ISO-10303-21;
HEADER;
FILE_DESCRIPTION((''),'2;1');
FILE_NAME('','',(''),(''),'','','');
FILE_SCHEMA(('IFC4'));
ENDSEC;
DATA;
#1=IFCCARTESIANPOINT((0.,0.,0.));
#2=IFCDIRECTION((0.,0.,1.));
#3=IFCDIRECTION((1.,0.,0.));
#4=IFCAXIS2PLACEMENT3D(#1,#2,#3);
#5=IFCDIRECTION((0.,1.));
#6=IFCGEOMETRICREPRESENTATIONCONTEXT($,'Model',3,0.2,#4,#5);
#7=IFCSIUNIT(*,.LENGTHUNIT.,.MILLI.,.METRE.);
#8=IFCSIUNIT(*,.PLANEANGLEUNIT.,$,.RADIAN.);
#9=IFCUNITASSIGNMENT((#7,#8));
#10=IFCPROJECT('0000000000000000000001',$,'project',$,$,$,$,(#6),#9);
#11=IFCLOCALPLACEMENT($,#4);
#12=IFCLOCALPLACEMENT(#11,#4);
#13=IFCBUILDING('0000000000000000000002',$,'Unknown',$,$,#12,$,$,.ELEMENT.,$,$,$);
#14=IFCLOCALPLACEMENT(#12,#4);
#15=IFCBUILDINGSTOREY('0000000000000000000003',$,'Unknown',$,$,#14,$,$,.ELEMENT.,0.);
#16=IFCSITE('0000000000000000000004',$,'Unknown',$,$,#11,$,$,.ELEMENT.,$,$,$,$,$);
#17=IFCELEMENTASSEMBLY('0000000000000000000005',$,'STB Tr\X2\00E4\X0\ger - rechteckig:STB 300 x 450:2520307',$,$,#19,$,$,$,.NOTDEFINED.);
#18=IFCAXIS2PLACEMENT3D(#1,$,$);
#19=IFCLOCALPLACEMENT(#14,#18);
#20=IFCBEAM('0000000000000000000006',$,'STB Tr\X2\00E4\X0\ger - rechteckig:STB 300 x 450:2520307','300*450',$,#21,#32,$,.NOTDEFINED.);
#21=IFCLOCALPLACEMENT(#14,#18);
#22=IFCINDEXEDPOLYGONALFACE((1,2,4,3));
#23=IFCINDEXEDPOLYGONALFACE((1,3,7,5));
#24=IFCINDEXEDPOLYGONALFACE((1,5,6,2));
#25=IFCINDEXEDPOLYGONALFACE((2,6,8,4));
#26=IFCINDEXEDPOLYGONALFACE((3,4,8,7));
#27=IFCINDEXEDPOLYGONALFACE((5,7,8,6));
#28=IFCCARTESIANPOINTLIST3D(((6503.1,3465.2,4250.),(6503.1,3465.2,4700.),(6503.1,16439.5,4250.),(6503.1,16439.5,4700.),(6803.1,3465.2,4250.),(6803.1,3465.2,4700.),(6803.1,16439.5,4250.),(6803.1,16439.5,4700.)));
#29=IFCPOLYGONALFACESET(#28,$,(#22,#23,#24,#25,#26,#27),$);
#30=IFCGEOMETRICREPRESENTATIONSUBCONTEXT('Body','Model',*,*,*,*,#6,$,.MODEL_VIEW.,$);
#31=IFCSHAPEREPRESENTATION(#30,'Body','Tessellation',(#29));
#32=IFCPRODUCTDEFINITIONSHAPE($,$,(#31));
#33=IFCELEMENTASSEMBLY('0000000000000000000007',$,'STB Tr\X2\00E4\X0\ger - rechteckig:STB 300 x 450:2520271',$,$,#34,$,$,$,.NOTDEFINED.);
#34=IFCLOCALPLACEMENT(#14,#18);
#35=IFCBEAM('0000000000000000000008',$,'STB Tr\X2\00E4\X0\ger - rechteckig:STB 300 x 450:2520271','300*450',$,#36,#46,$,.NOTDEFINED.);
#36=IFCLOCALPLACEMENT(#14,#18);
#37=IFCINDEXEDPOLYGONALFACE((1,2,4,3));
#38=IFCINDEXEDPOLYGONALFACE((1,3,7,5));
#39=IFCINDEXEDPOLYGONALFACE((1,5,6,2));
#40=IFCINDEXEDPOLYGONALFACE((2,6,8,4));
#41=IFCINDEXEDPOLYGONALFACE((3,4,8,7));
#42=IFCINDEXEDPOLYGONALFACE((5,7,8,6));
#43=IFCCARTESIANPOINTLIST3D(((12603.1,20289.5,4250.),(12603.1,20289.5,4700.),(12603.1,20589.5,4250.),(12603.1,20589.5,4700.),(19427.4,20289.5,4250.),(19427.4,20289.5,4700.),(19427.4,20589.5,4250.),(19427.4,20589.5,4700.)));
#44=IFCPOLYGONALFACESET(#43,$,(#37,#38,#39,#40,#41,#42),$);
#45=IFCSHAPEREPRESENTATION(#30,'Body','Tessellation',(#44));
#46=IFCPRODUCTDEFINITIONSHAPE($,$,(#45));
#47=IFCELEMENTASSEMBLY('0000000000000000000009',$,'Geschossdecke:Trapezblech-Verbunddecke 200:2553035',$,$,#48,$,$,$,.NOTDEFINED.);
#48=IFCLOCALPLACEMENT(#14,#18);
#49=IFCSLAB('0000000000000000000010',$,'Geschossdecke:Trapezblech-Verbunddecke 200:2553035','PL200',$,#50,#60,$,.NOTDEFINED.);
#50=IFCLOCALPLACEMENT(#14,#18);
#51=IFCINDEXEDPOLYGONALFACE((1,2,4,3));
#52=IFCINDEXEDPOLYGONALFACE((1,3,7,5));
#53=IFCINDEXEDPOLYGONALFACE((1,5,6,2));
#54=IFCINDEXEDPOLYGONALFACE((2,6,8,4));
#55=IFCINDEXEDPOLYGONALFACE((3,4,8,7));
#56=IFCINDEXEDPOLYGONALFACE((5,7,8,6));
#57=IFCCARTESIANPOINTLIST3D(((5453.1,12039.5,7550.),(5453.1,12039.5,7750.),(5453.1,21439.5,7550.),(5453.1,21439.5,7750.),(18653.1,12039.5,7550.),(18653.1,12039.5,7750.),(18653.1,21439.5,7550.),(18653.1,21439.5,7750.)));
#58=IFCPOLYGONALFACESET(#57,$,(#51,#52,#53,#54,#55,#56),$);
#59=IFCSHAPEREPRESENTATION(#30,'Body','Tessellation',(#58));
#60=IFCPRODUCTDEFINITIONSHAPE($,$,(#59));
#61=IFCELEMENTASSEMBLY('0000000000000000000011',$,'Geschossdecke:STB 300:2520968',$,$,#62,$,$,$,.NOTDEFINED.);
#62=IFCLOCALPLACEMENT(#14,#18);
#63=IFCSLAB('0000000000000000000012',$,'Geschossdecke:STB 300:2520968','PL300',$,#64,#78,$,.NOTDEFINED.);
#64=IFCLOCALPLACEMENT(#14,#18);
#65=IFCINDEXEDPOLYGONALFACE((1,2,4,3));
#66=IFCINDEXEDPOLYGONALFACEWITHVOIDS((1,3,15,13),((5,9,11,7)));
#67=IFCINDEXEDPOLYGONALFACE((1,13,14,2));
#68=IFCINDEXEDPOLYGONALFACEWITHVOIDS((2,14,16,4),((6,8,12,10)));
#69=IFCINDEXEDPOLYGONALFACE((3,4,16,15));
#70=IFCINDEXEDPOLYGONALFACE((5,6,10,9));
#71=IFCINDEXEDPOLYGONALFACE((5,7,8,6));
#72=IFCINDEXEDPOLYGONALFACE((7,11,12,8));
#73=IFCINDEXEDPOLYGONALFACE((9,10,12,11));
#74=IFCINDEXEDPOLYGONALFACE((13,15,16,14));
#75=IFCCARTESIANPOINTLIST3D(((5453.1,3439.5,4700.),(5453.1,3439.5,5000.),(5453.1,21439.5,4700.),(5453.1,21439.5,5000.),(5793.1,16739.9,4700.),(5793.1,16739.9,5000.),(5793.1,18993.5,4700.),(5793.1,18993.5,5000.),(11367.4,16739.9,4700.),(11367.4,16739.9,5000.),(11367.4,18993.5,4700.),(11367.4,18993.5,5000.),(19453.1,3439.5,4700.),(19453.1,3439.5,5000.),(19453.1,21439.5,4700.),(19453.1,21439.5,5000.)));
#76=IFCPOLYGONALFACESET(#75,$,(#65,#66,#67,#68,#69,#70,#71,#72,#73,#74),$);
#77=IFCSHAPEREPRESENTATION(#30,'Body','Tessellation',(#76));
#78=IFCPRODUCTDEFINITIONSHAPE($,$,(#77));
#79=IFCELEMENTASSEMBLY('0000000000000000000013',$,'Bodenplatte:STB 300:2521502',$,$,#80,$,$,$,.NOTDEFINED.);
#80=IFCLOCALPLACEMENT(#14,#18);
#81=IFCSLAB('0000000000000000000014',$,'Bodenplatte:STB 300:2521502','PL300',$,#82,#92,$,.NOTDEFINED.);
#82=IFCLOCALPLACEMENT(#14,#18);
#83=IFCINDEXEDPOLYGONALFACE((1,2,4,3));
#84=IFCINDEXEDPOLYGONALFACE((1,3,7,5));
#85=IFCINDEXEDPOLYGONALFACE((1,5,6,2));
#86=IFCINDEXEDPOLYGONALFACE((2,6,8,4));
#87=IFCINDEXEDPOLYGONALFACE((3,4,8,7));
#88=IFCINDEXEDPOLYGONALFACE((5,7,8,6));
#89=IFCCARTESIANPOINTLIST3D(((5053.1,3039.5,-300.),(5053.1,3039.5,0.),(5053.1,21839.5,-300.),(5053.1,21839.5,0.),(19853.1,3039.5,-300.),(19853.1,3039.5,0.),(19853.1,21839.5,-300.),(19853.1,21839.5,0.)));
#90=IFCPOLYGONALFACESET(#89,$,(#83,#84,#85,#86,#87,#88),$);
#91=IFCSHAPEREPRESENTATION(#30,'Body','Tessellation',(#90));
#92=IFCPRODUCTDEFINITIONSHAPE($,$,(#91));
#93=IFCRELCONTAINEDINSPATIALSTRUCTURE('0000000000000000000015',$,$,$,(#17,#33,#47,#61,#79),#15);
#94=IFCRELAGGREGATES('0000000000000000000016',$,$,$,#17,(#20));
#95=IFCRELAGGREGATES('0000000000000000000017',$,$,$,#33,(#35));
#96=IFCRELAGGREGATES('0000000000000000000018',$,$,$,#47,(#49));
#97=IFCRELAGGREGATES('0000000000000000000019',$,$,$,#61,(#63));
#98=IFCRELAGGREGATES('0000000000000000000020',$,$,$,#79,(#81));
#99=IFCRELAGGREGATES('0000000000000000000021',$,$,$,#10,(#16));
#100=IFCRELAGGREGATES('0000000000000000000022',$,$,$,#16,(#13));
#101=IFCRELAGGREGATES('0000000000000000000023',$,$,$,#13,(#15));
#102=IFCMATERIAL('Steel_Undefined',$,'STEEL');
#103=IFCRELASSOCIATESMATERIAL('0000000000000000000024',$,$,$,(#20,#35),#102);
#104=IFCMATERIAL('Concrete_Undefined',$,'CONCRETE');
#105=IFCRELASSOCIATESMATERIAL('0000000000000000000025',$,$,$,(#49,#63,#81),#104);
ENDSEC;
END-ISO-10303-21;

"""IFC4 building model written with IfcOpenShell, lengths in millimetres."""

from ifc_helpers import new_model, si_unit, direction, frame, origin_with_axes, place, context, subcontext, project, spatial, line, indexed_curve, outline, extrude, material, element, aggregate, save


model = new_model("IFC4")

# Units and contexts
model_context = context("Model", 3, precision=0.2, world=origin_with_axes(), true_north=direction((0.0, 1.0)))
body_context = subcontext(model_context, "Body", "Model", "MODEL_VIEW")
ifc_project = project(units=[si_unit("LENGTHUNIT", "METRE", prefix="MILLI"), si_unit("PLANEANGLEUNIT", "RADIAN")], contexts=[model_context])

# Site, building, storey
site_placement = place(None, origin_with_axes())
site = spatial("IfcSite", under=ifc_project, at=site_placement, Name="Unknown", CompositionType="ELEMENT")
building_placement = place(site_placement, origin_with_axes())
building = spatial("IfcBuilding", under=site, at=building_placement, Name="Unknown", CompositionType="ELEMENT")
storey_placement = place(building_placement, origin_with_axes())
storey = spatial("IfcBuildingStorey", under=building, at=storey_placement, Name="Unknown", CompositionType="ELEMENT", Elevation=0.0)

# Element assemblies, beams
assembly_1_placement = place(storey_placement, frame((6653.1, 16439.5, 4475.0), z_axis=(0.0, 0.0, 1.0), x_axis=(0.0, -1.0, 0.0)))
assembly_1 = element("IfcElementAssembly", 1, at=assembly_1_placement, inside=storey, Name="STB Träger - rechteckig:STB 300 x 450:2520307", PredefinedType="NOTDEFINED")
ifc_material_1 = material(Name="Steel_Undefined", Category="STEEL")
beam_1_placement = place(assembly_1_placement, origin_with_axes())
beam_1 = element("IfcBeam", 2, at=beam_1_placement, material=ifc_material_1, Name="STB Träger - rechteckig:STB 300 x 450:2520307", Description="300*450", PredefinedType="NOTDEFINED", context=body_context, shape_type="SolidModel", body=[
    extrude(outline(indexed_curve([(-225.0, -150.0), (225.0, -150.0), (225.0, 150.0), (-225.0, 150.0)], segments=[line(1, 2, 3, 4, 1)])), frame((0.0, 0.0, 0.0), z_axis=(-1.0, 0.0, 0.0), x_axis=(0.0, 0.0, 1.0)), (0.0, 0.0, -1.0), 12974.3),
])
aggregate(assembly_1, [beam_1])
assembly_2_placement = place(storey_placement, frame((12603.1, 20439.5, 4475.0), z_axis=(0.0, 0.0, 1.0), x_axis=(1.0, 0.0, 0.0)))
assembly_2 = element("IfcElementAssembly", 3, at=assembly_2_placement, inside=storey, Name="STB Träger - rechteckig:STB 300 x 450:2520271", PredefinedType="NOTDEFINED")
beam_2_placement = place(assembly_2_placement, origin_with_axes())
beam_2 = element("IfcBeam", 4, at=beam_2_placement, material=ifc_material_1, Name="STB Träger - rechteckig:STB 300 x 450:2520271", Description="300*450", PredefinedType="NOTDEFINED", context=body_context, shape_type="SolidModel", body=[
    extrude(outline(indexed_curve([(-225.0, -150.0), (225.0, -150.0), (225.0, 150.0), (-225.0, 150.0)], segments=[line(1, 2, 3, 4, 1)])), frame((0.0, 0.0, 0.0), z_axis=(-1.0, 0.0, 0.0), x_axis=(0.0, 0.0, 1.0)), (0.0, 0.0, -1.0), 6824.3),
])
aggregate(assembly_2, [beam_2])

# Element assembly, slab
assembly_3_placement = place(storey_placement, frame((5453.1, 21439.5, 7650.0), z_axis=(0.0, 0.0, 1.0), x_axis=(0.0, -1.0, 0.0)))
assembly_3 = element("IfcElementAssembly", 5, at=assembly_3_placement, inside=storey, Name="Geschossdecke:Trapezblech-Verbunddecke 200:2553035", PredefinedType="NOTDEFINED")
ifc_material_2 = material(Name="Concrete_Undefined", Category="CONCRETE")
slab_1_placement = place(assembly_3_placement, origin_with_axes())
slab_1 = element("IfcSlab", 6, at=slab_1_placement, material=ifc_material_2, Name="Geschossdecke:Trapezblech-Verbunddecke 200:2553035", Description="PL200", PredefinedType="NOTDEFINED", context=body_context, shape_type="SolidModel", body=[
    extrude(outline(indexed_curve([(0.0, 0.0), (9400.0, 0.0), (9400.0, 13200.0), (0.0, 13200.0)], segments=[line(1, 2, 3, 4, 1)])), frame((0.0, 0.0, 100.0), z_axis=(0.0, 0.0, 1.0), x_axis=(1.0, 0.0, 0.0)), (0.0, 0.0, -1.0), 200.0),
])
aggregate(assembly_3, [slab_1])

# Element assembly, slab, voiding feature
assembly_4_placement = place(storey_placement, frame((19453.1, 3439.5, 4850.0), z_axis=(0.0, 0.0, 1.0), x_axis=(0.0, 1.0, 0.0)))
assembly_4 = element("IfcElementAssembly", 7, at=assembly_4_placement, inside=storey, Name="Geschossdecke:STB 300:2520968", PredefinedType="NOTDEFINED")
slab_2_placement = place(assembly_4_placement, origin_with_axes())
slab_2 = element("IfcSlab", 8, at=slab_2_placement, material=ifc_material_2, Name="Geschossdecke:STB 300:2520968", Description="PL300", PredefinedType="NOTDEFINED", context=body_context, shape_type="SolidModel", body=[
    extrude(outline(indexed_curve([(0.0, 0.0), (18000.0, 0.0), (18000.0, 14000.0), (0.0, 14000.0)], segments=[line(1, 2, 3, 4, 1)])), frame((0.0, 0.0, 150.0), z_axis=(0.0, 0.0, 1.0), x_axis=(1.0, 0.0, 0.0)), (0.0, 0.0, -1.0), 300.0),
])
voiding_feature_placement = place(slab_2_placement, frame((14427.2, 10872.8, 150.0), z_axis=(-1.0, 0.0, 0.0), x_axis=(0.0, 0.0, -1.0)))
element("IfcVoidingFeature", 9, at=voiding_feature_placement, cuts=slab_2, Name="Geschossdecke:STB 300:712247", PredefinedType="HOLE", context=body_context, shape_type="SolidModel", body=[
    extrude(outline(indexed_curve([(-1126.8, -2787.2), (1126.8, -2787.2), (1126.8, 2787.2), (-1126.8, 2787.2)], segments=[line(1, 2, 3, 4, 1)])), frame((0.0, 0.0, 0.0), z_axis=(-1.0, 0.0, 0.0), x_axis=(0.0, 0.0, 1.0)), (0.0, 0.0, -1.0), 300.0),
])
aggregate(assembly_4, [slab_2])

# Element assembly, slab
assembly_5_placement = place(storey_placement, frame((5053.1, 21839.5, -150.0), z_axis=(0.0, 0.0, 1.0), x_axis=(0.0, -1.0, 0.0)))
assembly_5 = element("IfcElementAssembly", 10, at=assembly_5_placement, inside=storey, Name="Bodenplatte:STB 300:2521502", PredefinedType="NOTDEFINED")
slab_3_placement = place(assembly_5_placement, origin_with_axes())
slab_3 = element("IfcSlab", 11, at=slab_3_placement, material=ifc_material_2, Name="Bodenplatte:STB 300:2521502", Description="PL300", PredefinedType="NOTDEFINED", context=body_context, shape_type="SolidModel", body=[
    extrude(outline(indexed_curve([(0.0, 0.0), (18800.0, 0.0), (18800.0, 14800.0), (0.0, 14800.0)], segments=[line(1, 2, 3, 4, 1)])), frame((0.0, 0.0, 150.0), z_axis=(0.0, 0.0, 1.0), x_axis=(1.0, 0.0, 0.0)), (0.0, 0.0, -1.0), 300.0),
])
aggregate(assembly_5, [slab_3])

save(model, "model.ifc")
